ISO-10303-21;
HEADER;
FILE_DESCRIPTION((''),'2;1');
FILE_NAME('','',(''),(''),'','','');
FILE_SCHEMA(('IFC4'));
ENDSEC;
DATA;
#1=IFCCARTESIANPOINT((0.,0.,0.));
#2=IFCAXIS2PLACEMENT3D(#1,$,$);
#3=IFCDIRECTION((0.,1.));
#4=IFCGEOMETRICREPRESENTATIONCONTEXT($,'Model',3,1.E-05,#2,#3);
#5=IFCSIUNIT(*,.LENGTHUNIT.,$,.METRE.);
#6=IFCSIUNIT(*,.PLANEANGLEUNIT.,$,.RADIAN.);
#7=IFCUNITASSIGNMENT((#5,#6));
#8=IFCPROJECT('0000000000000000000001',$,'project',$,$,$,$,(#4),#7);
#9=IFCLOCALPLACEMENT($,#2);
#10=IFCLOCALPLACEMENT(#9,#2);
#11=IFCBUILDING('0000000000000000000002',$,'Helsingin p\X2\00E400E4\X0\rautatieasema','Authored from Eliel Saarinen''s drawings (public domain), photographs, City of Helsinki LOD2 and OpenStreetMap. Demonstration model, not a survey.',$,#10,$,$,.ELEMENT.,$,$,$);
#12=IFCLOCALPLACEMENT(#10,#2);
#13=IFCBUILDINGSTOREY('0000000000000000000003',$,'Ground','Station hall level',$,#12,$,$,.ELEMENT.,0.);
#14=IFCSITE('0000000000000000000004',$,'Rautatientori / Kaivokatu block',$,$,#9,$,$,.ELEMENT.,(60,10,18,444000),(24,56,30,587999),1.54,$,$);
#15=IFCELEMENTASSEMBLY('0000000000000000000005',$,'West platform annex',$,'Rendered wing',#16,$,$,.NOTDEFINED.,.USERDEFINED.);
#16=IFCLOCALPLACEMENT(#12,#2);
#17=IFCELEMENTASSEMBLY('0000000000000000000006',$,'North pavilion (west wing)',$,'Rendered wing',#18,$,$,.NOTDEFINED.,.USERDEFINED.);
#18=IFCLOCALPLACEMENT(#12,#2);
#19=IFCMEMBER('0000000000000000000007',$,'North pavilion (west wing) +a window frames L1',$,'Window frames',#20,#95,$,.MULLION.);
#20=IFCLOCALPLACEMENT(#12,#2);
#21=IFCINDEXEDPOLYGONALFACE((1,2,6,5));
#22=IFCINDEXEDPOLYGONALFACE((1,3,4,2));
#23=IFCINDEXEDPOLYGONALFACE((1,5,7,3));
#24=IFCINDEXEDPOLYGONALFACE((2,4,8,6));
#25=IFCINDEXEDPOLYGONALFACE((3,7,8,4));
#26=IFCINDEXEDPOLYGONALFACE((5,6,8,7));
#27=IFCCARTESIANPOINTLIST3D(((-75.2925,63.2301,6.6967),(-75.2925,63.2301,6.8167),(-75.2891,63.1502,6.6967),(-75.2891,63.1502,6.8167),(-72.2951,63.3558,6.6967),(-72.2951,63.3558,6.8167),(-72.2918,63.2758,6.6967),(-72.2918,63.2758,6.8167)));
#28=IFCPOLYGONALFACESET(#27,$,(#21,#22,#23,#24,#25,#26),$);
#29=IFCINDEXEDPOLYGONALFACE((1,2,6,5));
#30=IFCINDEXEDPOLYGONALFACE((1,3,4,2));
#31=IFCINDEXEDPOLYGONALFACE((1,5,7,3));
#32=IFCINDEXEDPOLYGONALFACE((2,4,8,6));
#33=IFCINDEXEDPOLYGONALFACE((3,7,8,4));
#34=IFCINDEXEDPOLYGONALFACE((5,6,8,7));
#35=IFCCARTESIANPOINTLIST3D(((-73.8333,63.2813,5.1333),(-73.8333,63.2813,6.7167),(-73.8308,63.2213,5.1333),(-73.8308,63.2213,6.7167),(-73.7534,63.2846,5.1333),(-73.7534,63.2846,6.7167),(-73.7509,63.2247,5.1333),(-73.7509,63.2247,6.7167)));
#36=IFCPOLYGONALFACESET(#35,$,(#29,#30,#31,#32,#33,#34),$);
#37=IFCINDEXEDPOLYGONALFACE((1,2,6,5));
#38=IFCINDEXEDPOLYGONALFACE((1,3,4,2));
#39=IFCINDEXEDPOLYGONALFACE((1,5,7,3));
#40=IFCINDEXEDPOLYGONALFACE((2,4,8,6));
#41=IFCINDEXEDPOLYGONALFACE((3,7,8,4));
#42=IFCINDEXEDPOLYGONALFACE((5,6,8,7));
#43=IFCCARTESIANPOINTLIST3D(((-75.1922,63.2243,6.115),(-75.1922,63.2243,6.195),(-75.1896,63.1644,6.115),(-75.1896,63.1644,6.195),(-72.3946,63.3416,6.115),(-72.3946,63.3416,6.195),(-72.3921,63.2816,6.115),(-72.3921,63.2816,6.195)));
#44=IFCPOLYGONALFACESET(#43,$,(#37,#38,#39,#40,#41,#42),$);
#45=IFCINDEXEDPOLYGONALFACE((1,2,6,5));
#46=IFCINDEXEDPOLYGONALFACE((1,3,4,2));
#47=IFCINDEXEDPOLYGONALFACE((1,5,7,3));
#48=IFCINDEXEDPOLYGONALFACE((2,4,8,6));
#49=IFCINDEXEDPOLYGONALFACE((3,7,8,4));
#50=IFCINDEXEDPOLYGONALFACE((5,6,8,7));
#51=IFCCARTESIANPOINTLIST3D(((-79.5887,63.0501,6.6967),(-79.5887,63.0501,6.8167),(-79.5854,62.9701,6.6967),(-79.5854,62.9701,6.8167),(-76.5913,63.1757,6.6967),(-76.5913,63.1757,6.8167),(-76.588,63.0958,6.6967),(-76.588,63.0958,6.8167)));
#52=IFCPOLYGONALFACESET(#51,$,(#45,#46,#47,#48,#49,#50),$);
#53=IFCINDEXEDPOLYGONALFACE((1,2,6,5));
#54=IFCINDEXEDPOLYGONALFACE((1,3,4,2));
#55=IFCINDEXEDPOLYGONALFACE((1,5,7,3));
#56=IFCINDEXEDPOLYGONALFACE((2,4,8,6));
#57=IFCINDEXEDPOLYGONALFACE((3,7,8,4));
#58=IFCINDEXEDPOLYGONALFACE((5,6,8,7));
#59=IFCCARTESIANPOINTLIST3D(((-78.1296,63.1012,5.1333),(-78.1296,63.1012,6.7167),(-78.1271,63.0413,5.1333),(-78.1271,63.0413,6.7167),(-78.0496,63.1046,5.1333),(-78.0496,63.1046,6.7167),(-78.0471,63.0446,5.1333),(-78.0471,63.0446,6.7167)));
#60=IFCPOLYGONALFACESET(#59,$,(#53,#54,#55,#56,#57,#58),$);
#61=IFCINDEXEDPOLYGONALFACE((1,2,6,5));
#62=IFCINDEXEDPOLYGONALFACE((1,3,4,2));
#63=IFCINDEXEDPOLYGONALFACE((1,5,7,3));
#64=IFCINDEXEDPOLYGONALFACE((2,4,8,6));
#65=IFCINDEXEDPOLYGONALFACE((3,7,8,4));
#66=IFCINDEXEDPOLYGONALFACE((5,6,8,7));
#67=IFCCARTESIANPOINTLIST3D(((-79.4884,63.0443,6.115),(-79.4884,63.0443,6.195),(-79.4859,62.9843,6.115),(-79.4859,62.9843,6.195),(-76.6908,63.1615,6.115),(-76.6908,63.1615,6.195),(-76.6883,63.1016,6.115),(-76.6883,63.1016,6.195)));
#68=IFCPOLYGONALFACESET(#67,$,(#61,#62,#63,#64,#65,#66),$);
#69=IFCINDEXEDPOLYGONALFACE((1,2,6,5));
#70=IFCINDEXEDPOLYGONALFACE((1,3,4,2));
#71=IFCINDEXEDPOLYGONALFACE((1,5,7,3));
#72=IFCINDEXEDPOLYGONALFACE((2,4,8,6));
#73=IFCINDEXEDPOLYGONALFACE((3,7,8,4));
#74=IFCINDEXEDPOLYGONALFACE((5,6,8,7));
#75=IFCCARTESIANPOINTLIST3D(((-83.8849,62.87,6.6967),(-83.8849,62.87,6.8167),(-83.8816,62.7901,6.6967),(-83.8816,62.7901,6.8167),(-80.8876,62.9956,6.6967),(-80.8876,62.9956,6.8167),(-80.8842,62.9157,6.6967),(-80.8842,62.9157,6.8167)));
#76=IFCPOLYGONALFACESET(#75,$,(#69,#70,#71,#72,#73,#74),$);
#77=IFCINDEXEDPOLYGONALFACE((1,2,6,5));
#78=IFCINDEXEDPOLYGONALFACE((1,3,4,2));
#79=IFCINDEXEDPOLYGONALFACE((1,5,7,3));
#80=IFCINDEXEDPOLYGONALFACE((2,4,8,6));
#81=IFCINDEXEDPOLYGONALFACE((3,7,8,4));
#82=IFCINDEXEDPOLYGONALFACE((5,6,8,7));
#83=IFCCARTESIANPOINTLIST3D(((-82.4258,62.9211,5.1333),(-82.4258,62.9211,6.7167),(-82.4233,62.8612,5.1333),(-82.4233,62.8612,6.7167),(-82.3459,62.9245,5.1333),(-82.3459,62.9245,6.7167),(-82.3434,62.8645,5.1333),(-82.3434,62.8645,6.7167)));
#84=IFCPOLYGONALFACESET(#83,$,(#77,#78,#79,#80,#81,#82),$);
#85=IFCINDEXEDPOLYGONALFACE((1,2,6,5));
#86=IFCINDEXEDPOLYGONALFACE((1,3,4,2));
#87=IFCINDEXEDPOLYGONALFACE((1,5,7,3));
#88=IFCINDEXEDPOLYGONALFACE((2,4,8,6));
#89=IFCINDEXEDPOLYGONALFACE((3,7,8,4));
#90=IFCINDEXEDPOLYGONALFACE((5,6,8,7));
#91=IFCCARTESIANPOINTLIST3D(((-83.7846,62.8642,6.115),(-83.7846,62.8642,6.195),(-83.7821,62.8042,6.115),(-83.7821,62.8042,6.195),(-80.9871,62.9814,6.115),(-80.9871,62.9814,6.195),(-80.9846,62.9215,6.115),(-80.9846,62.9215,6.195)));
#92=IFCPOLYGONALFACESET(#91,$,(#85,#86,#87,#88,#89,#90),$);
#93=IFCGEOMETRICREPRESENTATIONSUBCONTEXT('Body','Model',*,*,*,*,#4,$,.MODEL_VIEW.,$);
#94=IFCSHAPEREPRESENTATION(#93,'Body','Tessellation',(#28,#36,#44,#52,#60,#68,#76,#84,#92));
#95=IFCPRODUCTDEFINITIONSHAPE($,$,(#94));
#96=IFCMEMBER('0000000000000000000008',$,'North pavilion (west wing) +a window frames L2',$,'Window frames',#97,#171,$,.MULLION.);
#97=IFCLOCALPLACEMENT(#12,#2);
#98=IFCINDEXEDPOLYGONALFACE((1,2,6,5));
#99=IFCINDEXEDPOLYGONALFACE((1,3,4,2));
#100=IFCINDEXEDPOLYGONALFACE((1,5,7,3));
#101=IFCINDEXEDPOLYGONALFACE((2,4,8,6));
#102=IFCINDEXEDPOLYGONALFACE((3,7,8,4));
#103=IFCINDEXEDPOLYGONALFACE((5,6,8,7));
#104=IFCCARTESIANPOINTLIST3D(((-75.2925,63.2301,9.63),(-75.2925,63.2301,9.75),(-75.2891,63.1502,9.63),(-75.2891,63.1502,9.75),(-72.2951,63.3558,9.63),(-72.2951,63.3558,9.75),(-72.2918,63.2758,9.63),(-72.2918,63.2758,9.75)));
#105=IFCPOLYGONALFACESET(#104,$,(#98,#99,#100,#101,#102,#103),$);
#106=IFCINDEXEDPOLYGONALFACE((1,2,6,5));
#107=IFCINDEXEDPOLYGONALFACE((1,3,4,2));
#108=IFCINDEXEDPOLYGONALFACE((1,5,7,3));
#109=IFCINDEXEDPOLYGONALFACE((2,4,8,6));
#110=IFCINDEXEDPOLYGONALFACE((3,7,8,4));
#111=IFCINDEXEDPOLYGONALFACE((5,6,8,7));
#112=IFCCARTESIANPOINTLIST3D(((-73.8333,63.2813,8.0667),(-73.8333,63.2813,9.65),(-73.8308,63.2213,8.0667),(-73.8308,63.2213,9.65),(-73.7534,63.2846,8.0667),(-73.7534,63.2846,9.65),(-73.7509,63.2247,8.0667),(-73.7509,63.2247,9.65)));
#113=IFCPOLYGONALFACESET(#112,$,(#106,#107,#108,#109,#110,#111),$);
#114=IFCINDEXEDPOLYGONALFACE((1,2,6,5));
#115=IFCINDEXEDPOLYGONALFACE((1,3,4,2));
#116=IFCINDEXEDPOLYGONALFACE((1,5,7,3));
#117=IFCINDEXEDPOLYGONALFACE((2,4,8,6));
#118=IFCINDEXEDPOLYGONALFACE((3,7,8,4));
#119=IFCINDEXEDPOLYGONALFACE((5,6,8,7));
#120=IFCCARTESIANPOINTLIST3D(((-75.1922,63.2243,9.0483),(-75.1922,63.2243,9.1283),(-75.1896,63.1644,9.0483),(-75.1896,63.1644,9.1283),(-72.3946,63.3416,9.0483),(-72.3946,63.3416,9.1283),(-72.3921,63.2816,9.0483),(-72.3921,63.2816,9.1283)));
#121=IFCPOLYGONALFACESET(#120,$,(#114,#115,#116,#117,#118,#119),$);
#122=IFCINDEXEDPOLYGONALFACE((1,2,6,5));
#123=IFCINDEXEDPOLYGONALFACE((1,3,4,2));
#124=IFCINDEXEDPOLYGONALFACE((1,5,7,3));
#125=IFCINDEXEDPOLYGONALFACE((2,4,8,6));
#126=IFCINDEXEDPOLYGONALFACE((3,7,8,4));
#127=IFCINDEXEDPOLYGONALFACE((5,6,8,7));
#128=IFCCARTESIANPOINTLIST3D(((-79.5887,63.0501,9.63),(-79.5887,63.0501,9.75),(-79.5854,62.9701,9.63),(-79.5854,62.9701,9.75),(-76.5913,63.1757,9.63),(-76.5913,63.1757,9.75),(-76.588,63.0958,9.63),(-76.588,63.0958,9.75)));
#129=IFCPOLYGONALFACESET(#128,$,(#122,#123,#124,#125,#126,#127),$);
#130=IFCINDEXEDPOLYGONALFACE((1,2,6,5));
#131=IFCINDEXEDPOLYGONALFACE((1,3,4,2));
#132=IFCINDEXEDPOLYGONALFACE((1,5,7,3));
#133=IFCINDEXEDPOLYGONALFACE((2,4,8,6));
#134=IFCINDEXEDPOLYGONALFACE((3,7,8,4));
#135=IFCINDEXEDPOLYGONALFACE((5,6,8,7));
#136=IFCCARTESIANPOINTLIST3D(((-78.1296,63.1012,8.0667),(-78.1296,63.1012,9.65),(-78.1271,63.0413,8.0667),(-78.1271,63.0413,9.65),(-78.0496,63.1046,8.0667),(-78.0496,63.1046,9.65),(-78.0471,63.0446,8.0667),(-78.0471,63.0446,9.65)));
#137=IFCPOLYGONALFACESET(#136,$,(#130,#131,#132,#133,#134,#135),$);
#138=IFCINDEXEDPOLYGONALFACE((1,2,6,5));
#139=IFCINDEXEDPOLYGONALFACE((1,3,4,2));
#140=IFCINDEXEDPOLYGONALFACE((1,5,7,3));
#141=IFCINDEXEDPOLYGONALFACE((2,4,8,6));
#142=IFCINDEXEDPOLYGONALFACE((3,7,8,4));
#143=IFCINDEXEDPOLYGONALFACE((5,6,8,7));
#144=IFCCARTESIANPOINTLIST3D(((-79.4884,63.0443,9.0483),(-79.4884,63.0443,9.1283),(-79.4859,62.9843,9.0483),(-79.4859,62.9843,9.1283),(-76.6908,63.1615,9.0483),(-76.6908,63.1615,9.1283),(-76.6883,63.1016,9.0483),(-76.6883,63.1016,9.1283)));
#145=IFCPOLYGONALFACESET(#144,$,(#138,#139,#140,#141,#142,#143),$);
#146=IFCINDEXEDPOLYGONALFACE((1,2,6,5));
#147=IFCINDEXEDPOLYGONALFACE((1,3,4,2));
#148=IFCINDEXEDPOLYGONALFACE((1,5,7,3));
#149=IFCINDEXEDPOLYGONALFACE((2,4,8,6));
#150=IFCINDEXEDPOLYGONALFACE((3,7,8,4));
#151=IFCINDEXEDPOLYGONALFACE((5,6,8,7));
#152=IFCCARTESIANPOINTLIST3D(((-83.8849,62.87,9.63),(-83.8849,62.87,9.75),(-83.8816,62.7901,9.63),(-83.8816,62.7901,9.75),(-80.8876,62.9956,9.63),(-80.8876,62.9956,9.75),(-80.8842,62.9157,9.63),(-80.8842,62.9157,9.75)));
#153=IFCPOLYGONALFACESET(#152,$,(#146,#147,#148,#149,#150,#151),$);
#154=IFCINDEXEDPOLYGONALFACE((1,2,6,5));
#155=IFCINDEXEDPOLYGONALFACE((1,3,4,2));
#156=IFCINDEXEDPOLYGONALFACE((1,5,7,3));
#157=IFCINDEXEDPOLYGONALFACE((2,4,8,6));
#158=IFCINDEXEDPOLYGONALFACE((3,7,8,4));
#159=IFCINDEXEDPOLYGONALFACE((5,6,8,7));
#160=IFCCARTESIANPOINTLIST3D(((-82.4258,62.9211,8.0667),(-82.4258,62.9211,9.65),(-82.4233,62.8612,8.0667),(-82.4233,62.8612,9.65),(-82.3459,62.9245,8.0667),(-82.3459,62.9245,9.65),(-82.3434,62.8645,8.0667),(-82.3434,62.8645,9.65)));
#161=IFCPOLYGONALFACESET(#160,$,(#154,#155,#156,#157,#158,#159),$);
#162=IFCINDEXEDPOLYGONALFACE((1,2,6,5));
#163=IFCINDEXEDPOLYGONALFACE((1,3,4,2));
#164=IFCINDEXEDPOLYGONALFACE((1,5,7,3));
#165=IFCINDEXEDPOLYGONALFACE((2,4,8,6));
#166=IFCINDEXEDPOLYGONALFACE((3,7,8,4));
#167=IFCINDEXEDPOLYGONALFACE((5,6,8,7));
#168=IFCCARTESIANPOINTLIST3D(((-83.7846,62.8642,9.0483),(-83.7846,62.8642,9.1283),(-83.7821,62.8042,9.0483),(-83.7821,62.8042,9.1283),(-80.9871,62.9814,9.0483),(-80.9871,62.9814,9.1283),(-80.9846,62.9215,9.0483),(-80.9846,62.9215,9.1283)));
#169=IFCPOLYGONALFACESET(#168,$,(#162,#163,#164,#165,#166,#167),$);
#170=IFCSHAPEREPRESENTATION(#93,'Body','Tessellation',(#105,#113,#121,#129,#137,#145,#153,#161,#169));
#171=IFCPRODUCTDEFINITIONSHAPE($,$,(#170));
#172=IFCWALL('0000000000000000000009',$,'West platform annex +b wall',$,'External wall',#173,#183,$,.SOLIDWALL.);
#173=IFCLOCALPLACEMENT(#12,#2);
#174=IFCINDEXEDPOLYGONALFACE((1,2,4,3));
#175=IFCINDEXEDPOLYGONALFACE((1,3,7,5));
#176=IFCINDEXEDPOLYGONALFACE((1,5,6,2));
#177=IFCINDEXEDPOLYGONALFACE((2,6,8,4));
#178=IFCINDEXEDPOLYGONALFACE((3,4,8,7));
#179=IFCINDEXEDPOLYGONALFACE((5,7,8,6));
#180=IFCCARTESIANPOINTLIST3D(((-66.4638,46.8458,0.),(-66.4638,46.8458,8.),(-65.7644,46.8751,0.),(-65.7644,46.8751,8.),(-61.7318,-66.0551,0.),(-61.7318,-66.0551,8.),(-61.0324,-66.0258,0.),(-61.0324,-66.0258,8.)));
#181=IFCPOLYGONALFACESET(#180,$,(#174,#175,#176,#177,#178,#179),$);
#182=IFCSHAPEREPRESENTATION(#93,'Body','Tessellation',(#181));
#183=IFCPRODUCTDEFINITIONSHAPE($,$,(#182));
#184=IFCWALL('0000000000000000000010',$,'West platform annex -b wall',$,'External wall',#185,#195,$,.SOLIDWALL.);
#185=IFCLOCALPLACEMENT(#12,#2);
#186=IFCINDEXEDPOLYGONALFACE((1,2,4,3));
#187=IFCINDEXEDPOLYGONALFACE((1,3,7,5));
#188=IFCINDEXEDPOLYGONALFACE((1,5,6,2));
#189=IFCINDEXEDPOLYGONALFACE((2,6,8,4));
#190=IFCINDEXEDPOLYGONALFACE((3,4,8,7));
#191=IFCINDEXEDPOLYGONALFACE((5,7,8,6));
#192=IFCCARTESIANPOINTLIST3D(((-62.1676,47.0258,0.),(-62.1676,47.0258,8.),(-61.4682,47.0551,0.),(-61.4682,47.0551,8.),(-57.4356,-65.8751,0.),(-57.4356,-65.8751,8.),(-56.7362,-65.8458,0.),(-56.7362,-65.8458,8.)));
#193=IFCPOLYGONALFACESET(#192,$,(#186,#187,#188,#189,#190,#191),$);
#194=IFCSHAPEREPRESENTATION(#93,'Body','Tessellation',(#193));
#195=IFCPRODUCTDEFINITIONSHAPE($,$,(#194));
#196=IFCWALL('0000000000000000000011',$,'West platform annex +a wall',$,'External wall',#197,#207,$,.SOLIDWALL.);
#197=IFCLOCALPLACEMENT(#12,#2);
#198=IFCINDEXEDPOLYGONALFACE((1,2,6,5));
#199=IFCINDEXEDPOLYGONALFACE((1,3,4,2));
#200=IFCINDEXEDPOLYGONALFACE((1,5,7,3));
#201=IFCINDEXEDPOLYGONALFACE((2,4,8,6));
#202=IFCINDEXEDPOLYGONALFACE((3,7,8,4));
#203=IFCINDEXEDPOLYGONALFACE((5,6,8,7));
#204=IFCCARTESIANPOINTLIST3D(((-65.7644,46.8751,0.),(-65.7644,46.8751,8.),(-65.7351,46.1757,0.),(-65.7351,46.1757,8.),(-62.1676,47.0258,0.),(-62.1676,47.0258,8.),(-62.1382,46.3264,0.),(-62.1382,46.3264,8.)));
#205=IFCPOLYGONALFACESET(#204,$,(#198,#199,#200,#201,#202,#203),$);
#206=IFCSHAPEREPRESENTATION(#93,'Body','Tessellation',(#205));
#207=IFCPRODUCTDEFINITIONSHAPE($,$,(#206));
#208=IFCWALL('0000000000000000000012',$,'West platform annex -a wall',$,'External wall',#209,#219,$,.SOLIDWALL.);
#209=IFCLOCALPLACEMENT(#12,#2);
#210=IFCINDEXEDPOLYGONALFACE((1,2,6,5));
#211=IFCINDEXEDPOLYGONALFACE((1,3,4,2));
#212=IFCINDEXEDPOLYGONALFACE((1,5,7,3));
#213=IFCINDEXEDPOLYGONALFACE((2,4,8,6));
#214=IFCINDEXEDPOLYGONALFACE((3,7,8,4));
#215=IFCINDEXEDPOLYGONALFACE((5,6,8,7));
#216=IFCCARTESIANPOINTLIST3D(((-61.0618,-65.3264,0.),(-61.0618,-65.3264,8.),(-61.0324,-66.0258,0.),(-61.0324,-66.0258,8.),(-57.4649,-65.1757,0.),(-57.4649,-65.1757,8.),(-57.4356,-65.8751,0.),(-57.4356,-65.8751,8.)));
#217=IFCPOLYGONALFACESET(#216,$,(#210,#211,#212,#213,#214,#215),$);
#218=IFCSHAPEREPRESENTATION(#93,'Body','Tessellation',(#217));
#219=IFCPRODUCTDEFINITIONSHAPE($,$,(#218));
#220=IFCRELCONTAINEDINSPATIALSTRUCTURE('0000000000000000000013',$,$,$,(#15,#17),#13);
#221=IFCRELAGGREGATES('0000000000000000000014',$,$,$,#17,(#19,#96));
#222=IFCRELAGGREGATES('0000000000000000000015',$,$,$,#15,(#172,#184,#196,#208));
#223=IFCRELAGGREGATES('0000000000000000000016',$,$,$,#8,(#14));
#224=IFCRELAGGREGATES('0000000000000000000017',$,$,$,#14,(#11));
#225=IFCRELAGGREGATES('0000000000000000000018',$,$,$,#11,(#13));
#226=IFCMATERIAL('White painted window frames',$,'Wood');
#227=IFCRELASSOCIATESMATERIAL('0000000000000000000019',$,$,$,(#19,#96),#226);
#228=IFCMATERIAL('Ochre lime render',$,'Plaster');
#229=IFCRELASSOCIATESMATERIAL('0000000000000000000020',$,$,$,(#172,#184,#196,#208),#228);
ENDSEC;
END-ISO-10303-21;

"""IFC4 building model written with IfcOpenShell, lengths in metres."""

from ifc_helpers import new_model, si_unit, direction, frame, frame_2d, origin, place, context, subcontext, project, spatial, rectangle, extrude, material, element, aggregate, save


model = new_model("IFC4")

# Units and contexts
model_context = context("Model", 3, precision=1e-05, world=origin(), true_north=direction((0.0, 1.0)))
body_context = subcontext(model_context, "Body", "Model", "MODEL_VIEW")
ifc_project = project(units=[si_unit("LENGTHUNIT", "METRE"), si_unit("PLANEANGLEUNIT", "RADIAN")], contexts=[model_context])

# Site, building, storey
site_placement = place(None, origin())
site = spatial("IfcSite", under=ifc_project, at=site_placement, Name="Rautatientori / Kaivokatu block", CompositionType="ELEMENT", RefLatitude=(60, 10, 18, 444000), RefLongitude=(24, 56, 30, 587999), RefElevation=1.54)
building_placement = place(site_placement, origin())
building = spatial("IfcBuilding", under=site, at=building_placement, Name="Helsingin päärautatieasema", Description="Authored from Eliel Saarinen's drawings (public domain), photographs, City of Helsinki LOD2 and OpenStreetMap. Demonstration model, not a survey.", CompositionType="ELEMENT")
storey_placement = place(building_placement, origin())
storey = spatial("IfcBuildingStorey", under=building, at=storey_placement, Name="Ground", Description="Station hall level", CompositionType="ELEMENT", Elevation=0.0)

# Element assembly
assembly_1_placement = place(building_placement, origin())
assembly_1 = element("IfcElementAssembly", 1, at=assembly_1_placement, inside=storey, Name="West platform annex", ObjectType="Rendered wing", AssemblyPlace="NOTDEFINED", PredefinedType="USERDEFINED")
ifc_material_1 = material(Name="White painted window frames", Category="Wood")
ifc_material_2 = material(Name="Ochre lime render", Category="Plaster")

# Element assembly, members
assembly_2_placement = place(building_placement, origin())
assembly_2 = element("IfcElementAssembly", 2, at=assembly_2_placement, inside=storey, Name="North pavilion (west wing)", ObjectType="Rendered wing", AssemblyPlace="NOTDEFINED", PredefinedType="USERDEFINED")
member_1_placement = place(building_placement, origin())
member_1 = element("IfcMember", 3, at=member_1_placement, material=ifc_material_1, Name="North pavilion (west wing) +a window frames L1", ObjectType="Window frames", PredefinedType="MULLION", context=body_context, shape_type="SweptSolid", body=[
    extrude(rectangle(XDim=3.0, YDim=0.08, at=frame_2d((0.0, 0.0), x_axis=(-0.999123, -0.041876))), frame((-73.7921, 63.253, 6.6967)), (0.0, 0.0, 1.0), 0.12),
    extrude(rectangle(XDim=0.08, YDim=0.06, at=frame_2d((0.0, 0.0), x_axis=(-0.999123, -0.041876))), frame((-73.7921, 63.253, 5.1333)), (0.0, 0.0, 1.0), 1.5833),
    extrude(rectangle(XDim=2.8, YDim=0.06, at=frame_2d((0.0, 0.0), x_axis=(-0.999123, -0.041876))), frame((-73.7921, 63.253, 6.115)), (0.0, 0.0, 1.0), 0.08),
    extrude(rectangle(XDim=3.0, YDim=0.08, at=frame_2d((0.0, 0.0), x_axis=(-0.999123, -0.041876))), frame((-78.0884, 63.0729, 6.6967)), (0.0, 0.0, 1.0), 0.12),
    extrude(rectangle(XDim=0.08, YDim=0.06, at=frame_2d((0.0, 0.0), x_axis=(-0.999123, -0.041876))), frame((-78.0884, 63.0729, 5.1333)), (0.0, 0.0, 1.0), 1.5833),
    extrude(rectangle(XDim=2.8, YDim=0.06, at=frame_2d((0.0, 0.0), x_axis=(-0.999123, -0.041876))), frame((-78.0884, 63.0729, 6.115)), (0.0, 0.0, 1.0), 0.08),
    extrude(rectangle(XDim=3.0, YDim=0.08, at=frame_2d((0.0, 0.0), x_axis=(-0.999123, -0.041876))), frame((-82.3846, 62.8928, 6.6967)), (0.0, 0.0, 1.0), 0.12),
    extrude(rectangle(XDim=0.08, YDim=0.06, at=frame_2d((0.0, 0.0), x_axis=(-0.999123, -0.041876))), frame((-82.3846, 62.8928, 5.1333)), (0.0, 0.0, 1.0), 1.5833),
    extrude(rectangle(XDim=2.8, YDim=0.06, at=frame_2d((0.0, 0.0), x_axis=(-0.999123, -0.041876))), frame((-82.3846, 62.8928, 6.115)), (0.0, 0.0, 1.0), 0.08),
])
member_2_placement = place(building_placement, origin())
member_2 = element("IfcMember", 4, at=member_2_placement, material=ifc_material_1, Name="North pavilion (west wing) +a window frames L2", ObjectType="Window frames", PredefinedType="MULLION", context=body_context, shape_type="SweptSolid", body=[
    extrude(rectangle(XDim=3.0, YDim=0.08, at=frame_2d((0.0, 0.0), x_axis=(-0.999123, -0.041876))), frame((-73.7921, 63.253, 9.63)), (0.0, 0.0, 1.0), 0.12),
    extrude(rectangle(XDim=0.08, YDim=0.06, at=frame_2d((0.0, 0.0), x_axis=(-0.999123, -0.041876))), frame((-73.7921, 63.253, 8.0667)), (0.0, 0.0, 1.0), 1.5833),
    extrude(rectangle(XDim=2.8, YDim=0.06, at=frame_2d((0.0, 0.0), x_axis=(-0.999123, -0.041876))), frame((-73.7921, 63.253, 9.0483)), (0.0, 0.0, 1.0), 0.08),
    extrude(rectangle(XDim=3.0, YDim=0.08, at=frame_2d((0.0, 0.0), x_axis=(-0.999123, -0.041876))), frame((-78.0884, 63.0729, 9.63)), (0.0, 0.0, 1.0), 0.12),
    extrude(rectangle(XDim=0.08, YDim=0.06, at=frame_2d((0.0, 0.0), x_axis=(-0.999123, -0.041876))), frame((-78.0884, 63.0729, 8.0667)), (0.0, 0.0, 1.0), 1.5833),
    extrude(rectangle(XDim=2.8, YDim=0.06, at=frame_2d((0.0, 0.0), x_axis=(-0.999123, -0.041876))), frame((-78.0884, 63.0729, 9.0483)), (0.0, 0.0, 1.0), 0.08),
    extrude(rectangle(XDim=3.0, YDim=0.08, at=frame_2d((0.0, 0.0), x_axis=(-0.999123, -0.041876))), frame((-82.3846, 62.8928, 9.63)), (0.0, 0.0, 1.0), 0.12),
    extrude(rectangle(XDim=0.08, YDim=0.06, at=frame_2d((0.0, 0.0), x_axis=(-0.999123, -0.041876))), frame((-82.3846, 62.8928, 8.0667)), (0.0, 0.0, 1.0), 1.5833),
    extrude(rectangle(XDim=2.8, YDim=0.06, at=frame_2d((0.0, 0.0), x_axis=(-0.999123, -0.041876))), frame((-82.3846, 62.8928, 9.0483)), (0.0, 0.0, 1.0), 0.08),
])

# Walls
wall_1_placement = place(building_placement, origin())
wall_1 = element("IfcWall", 5, at=wall_1_placement, material=ifc_material_2, Name="West platform annex +b wall", ObjectType="External wall", PredefinedType="SOLIDWALL", context=body_context, shape_type="SweptSolid", body=[
    extrude(rectangle(XDim=113.0, YDim=0.7, at=frame_2d((0.0, 0.0), x_axis=(0.041876, -0.999123))), frame((-63.7481, -9.59, 0.0)), (0.0, 0.0, 1.0), 8.0),
])
wall_2_placement = place(building_placement, origin())
wall_2 = element("IfcWall", 6, at=wall_2_placement, material=ifc_material_2, Name="West platform annex -b wall", ObjectType="External wall", PredefinedType="SOLIDWALL", context=body_context, shape_type="SweptSolid", body=[
    extrude(rectangle(XDim=113.0, YDim=0.7, at=frame_2d((0.0, 0.0), x_axis=(-0.041876, 0.999123))), frame((-59.4519, -9.41, 0.0)), (0.0, 0.0, 1.0), 8.0),
])
wall_3_placement = place(building_placement, origin())
wall_3 = element("IfcWall", 7, at=wall_3_placement, material=ifc_material_2, Name="West platform annex +a wall", ObjectType="External wall", PredefinedType="SOLIDWALL", context=body_context, shape_type="SweptSolid", body=[
    extrude(rectangle(XDim=3.6, YDim=0.7, at=frame_2d((0.0, 0.0), x_axis=(-0.999123, -0.041876))), frame((-63.9513, 46.6007, 0.0)), (0.0, 0.0, 1.0), 8.0),
])
wall_4_placement = place(building_placement, origin())
wall_4 = element("IfcWall", 8, at=wall_4_placement, material=ifc_material_2, Name="West platform annex -a wall", ObjectType="External wall", PredefinedType="SOLIDWALL", context=body_context, shape_type="SweptSolid", body=[
    extrude(rectangle(XDim=3.6, YDim=0.7, at=frame_2d((0.0, 0.0), x_axis=(0.999123, 0.041876))), frame((-59.2487, -65.6007, 0.0)), (0.0, 0.0, 1.0), 8.0),
])

aggregate(assembly_2, [member_1, member_2])

aggregate(assembly_1, [wall_1, wall_2, wall_3, wall_4])

save(model, "model.ifc")
